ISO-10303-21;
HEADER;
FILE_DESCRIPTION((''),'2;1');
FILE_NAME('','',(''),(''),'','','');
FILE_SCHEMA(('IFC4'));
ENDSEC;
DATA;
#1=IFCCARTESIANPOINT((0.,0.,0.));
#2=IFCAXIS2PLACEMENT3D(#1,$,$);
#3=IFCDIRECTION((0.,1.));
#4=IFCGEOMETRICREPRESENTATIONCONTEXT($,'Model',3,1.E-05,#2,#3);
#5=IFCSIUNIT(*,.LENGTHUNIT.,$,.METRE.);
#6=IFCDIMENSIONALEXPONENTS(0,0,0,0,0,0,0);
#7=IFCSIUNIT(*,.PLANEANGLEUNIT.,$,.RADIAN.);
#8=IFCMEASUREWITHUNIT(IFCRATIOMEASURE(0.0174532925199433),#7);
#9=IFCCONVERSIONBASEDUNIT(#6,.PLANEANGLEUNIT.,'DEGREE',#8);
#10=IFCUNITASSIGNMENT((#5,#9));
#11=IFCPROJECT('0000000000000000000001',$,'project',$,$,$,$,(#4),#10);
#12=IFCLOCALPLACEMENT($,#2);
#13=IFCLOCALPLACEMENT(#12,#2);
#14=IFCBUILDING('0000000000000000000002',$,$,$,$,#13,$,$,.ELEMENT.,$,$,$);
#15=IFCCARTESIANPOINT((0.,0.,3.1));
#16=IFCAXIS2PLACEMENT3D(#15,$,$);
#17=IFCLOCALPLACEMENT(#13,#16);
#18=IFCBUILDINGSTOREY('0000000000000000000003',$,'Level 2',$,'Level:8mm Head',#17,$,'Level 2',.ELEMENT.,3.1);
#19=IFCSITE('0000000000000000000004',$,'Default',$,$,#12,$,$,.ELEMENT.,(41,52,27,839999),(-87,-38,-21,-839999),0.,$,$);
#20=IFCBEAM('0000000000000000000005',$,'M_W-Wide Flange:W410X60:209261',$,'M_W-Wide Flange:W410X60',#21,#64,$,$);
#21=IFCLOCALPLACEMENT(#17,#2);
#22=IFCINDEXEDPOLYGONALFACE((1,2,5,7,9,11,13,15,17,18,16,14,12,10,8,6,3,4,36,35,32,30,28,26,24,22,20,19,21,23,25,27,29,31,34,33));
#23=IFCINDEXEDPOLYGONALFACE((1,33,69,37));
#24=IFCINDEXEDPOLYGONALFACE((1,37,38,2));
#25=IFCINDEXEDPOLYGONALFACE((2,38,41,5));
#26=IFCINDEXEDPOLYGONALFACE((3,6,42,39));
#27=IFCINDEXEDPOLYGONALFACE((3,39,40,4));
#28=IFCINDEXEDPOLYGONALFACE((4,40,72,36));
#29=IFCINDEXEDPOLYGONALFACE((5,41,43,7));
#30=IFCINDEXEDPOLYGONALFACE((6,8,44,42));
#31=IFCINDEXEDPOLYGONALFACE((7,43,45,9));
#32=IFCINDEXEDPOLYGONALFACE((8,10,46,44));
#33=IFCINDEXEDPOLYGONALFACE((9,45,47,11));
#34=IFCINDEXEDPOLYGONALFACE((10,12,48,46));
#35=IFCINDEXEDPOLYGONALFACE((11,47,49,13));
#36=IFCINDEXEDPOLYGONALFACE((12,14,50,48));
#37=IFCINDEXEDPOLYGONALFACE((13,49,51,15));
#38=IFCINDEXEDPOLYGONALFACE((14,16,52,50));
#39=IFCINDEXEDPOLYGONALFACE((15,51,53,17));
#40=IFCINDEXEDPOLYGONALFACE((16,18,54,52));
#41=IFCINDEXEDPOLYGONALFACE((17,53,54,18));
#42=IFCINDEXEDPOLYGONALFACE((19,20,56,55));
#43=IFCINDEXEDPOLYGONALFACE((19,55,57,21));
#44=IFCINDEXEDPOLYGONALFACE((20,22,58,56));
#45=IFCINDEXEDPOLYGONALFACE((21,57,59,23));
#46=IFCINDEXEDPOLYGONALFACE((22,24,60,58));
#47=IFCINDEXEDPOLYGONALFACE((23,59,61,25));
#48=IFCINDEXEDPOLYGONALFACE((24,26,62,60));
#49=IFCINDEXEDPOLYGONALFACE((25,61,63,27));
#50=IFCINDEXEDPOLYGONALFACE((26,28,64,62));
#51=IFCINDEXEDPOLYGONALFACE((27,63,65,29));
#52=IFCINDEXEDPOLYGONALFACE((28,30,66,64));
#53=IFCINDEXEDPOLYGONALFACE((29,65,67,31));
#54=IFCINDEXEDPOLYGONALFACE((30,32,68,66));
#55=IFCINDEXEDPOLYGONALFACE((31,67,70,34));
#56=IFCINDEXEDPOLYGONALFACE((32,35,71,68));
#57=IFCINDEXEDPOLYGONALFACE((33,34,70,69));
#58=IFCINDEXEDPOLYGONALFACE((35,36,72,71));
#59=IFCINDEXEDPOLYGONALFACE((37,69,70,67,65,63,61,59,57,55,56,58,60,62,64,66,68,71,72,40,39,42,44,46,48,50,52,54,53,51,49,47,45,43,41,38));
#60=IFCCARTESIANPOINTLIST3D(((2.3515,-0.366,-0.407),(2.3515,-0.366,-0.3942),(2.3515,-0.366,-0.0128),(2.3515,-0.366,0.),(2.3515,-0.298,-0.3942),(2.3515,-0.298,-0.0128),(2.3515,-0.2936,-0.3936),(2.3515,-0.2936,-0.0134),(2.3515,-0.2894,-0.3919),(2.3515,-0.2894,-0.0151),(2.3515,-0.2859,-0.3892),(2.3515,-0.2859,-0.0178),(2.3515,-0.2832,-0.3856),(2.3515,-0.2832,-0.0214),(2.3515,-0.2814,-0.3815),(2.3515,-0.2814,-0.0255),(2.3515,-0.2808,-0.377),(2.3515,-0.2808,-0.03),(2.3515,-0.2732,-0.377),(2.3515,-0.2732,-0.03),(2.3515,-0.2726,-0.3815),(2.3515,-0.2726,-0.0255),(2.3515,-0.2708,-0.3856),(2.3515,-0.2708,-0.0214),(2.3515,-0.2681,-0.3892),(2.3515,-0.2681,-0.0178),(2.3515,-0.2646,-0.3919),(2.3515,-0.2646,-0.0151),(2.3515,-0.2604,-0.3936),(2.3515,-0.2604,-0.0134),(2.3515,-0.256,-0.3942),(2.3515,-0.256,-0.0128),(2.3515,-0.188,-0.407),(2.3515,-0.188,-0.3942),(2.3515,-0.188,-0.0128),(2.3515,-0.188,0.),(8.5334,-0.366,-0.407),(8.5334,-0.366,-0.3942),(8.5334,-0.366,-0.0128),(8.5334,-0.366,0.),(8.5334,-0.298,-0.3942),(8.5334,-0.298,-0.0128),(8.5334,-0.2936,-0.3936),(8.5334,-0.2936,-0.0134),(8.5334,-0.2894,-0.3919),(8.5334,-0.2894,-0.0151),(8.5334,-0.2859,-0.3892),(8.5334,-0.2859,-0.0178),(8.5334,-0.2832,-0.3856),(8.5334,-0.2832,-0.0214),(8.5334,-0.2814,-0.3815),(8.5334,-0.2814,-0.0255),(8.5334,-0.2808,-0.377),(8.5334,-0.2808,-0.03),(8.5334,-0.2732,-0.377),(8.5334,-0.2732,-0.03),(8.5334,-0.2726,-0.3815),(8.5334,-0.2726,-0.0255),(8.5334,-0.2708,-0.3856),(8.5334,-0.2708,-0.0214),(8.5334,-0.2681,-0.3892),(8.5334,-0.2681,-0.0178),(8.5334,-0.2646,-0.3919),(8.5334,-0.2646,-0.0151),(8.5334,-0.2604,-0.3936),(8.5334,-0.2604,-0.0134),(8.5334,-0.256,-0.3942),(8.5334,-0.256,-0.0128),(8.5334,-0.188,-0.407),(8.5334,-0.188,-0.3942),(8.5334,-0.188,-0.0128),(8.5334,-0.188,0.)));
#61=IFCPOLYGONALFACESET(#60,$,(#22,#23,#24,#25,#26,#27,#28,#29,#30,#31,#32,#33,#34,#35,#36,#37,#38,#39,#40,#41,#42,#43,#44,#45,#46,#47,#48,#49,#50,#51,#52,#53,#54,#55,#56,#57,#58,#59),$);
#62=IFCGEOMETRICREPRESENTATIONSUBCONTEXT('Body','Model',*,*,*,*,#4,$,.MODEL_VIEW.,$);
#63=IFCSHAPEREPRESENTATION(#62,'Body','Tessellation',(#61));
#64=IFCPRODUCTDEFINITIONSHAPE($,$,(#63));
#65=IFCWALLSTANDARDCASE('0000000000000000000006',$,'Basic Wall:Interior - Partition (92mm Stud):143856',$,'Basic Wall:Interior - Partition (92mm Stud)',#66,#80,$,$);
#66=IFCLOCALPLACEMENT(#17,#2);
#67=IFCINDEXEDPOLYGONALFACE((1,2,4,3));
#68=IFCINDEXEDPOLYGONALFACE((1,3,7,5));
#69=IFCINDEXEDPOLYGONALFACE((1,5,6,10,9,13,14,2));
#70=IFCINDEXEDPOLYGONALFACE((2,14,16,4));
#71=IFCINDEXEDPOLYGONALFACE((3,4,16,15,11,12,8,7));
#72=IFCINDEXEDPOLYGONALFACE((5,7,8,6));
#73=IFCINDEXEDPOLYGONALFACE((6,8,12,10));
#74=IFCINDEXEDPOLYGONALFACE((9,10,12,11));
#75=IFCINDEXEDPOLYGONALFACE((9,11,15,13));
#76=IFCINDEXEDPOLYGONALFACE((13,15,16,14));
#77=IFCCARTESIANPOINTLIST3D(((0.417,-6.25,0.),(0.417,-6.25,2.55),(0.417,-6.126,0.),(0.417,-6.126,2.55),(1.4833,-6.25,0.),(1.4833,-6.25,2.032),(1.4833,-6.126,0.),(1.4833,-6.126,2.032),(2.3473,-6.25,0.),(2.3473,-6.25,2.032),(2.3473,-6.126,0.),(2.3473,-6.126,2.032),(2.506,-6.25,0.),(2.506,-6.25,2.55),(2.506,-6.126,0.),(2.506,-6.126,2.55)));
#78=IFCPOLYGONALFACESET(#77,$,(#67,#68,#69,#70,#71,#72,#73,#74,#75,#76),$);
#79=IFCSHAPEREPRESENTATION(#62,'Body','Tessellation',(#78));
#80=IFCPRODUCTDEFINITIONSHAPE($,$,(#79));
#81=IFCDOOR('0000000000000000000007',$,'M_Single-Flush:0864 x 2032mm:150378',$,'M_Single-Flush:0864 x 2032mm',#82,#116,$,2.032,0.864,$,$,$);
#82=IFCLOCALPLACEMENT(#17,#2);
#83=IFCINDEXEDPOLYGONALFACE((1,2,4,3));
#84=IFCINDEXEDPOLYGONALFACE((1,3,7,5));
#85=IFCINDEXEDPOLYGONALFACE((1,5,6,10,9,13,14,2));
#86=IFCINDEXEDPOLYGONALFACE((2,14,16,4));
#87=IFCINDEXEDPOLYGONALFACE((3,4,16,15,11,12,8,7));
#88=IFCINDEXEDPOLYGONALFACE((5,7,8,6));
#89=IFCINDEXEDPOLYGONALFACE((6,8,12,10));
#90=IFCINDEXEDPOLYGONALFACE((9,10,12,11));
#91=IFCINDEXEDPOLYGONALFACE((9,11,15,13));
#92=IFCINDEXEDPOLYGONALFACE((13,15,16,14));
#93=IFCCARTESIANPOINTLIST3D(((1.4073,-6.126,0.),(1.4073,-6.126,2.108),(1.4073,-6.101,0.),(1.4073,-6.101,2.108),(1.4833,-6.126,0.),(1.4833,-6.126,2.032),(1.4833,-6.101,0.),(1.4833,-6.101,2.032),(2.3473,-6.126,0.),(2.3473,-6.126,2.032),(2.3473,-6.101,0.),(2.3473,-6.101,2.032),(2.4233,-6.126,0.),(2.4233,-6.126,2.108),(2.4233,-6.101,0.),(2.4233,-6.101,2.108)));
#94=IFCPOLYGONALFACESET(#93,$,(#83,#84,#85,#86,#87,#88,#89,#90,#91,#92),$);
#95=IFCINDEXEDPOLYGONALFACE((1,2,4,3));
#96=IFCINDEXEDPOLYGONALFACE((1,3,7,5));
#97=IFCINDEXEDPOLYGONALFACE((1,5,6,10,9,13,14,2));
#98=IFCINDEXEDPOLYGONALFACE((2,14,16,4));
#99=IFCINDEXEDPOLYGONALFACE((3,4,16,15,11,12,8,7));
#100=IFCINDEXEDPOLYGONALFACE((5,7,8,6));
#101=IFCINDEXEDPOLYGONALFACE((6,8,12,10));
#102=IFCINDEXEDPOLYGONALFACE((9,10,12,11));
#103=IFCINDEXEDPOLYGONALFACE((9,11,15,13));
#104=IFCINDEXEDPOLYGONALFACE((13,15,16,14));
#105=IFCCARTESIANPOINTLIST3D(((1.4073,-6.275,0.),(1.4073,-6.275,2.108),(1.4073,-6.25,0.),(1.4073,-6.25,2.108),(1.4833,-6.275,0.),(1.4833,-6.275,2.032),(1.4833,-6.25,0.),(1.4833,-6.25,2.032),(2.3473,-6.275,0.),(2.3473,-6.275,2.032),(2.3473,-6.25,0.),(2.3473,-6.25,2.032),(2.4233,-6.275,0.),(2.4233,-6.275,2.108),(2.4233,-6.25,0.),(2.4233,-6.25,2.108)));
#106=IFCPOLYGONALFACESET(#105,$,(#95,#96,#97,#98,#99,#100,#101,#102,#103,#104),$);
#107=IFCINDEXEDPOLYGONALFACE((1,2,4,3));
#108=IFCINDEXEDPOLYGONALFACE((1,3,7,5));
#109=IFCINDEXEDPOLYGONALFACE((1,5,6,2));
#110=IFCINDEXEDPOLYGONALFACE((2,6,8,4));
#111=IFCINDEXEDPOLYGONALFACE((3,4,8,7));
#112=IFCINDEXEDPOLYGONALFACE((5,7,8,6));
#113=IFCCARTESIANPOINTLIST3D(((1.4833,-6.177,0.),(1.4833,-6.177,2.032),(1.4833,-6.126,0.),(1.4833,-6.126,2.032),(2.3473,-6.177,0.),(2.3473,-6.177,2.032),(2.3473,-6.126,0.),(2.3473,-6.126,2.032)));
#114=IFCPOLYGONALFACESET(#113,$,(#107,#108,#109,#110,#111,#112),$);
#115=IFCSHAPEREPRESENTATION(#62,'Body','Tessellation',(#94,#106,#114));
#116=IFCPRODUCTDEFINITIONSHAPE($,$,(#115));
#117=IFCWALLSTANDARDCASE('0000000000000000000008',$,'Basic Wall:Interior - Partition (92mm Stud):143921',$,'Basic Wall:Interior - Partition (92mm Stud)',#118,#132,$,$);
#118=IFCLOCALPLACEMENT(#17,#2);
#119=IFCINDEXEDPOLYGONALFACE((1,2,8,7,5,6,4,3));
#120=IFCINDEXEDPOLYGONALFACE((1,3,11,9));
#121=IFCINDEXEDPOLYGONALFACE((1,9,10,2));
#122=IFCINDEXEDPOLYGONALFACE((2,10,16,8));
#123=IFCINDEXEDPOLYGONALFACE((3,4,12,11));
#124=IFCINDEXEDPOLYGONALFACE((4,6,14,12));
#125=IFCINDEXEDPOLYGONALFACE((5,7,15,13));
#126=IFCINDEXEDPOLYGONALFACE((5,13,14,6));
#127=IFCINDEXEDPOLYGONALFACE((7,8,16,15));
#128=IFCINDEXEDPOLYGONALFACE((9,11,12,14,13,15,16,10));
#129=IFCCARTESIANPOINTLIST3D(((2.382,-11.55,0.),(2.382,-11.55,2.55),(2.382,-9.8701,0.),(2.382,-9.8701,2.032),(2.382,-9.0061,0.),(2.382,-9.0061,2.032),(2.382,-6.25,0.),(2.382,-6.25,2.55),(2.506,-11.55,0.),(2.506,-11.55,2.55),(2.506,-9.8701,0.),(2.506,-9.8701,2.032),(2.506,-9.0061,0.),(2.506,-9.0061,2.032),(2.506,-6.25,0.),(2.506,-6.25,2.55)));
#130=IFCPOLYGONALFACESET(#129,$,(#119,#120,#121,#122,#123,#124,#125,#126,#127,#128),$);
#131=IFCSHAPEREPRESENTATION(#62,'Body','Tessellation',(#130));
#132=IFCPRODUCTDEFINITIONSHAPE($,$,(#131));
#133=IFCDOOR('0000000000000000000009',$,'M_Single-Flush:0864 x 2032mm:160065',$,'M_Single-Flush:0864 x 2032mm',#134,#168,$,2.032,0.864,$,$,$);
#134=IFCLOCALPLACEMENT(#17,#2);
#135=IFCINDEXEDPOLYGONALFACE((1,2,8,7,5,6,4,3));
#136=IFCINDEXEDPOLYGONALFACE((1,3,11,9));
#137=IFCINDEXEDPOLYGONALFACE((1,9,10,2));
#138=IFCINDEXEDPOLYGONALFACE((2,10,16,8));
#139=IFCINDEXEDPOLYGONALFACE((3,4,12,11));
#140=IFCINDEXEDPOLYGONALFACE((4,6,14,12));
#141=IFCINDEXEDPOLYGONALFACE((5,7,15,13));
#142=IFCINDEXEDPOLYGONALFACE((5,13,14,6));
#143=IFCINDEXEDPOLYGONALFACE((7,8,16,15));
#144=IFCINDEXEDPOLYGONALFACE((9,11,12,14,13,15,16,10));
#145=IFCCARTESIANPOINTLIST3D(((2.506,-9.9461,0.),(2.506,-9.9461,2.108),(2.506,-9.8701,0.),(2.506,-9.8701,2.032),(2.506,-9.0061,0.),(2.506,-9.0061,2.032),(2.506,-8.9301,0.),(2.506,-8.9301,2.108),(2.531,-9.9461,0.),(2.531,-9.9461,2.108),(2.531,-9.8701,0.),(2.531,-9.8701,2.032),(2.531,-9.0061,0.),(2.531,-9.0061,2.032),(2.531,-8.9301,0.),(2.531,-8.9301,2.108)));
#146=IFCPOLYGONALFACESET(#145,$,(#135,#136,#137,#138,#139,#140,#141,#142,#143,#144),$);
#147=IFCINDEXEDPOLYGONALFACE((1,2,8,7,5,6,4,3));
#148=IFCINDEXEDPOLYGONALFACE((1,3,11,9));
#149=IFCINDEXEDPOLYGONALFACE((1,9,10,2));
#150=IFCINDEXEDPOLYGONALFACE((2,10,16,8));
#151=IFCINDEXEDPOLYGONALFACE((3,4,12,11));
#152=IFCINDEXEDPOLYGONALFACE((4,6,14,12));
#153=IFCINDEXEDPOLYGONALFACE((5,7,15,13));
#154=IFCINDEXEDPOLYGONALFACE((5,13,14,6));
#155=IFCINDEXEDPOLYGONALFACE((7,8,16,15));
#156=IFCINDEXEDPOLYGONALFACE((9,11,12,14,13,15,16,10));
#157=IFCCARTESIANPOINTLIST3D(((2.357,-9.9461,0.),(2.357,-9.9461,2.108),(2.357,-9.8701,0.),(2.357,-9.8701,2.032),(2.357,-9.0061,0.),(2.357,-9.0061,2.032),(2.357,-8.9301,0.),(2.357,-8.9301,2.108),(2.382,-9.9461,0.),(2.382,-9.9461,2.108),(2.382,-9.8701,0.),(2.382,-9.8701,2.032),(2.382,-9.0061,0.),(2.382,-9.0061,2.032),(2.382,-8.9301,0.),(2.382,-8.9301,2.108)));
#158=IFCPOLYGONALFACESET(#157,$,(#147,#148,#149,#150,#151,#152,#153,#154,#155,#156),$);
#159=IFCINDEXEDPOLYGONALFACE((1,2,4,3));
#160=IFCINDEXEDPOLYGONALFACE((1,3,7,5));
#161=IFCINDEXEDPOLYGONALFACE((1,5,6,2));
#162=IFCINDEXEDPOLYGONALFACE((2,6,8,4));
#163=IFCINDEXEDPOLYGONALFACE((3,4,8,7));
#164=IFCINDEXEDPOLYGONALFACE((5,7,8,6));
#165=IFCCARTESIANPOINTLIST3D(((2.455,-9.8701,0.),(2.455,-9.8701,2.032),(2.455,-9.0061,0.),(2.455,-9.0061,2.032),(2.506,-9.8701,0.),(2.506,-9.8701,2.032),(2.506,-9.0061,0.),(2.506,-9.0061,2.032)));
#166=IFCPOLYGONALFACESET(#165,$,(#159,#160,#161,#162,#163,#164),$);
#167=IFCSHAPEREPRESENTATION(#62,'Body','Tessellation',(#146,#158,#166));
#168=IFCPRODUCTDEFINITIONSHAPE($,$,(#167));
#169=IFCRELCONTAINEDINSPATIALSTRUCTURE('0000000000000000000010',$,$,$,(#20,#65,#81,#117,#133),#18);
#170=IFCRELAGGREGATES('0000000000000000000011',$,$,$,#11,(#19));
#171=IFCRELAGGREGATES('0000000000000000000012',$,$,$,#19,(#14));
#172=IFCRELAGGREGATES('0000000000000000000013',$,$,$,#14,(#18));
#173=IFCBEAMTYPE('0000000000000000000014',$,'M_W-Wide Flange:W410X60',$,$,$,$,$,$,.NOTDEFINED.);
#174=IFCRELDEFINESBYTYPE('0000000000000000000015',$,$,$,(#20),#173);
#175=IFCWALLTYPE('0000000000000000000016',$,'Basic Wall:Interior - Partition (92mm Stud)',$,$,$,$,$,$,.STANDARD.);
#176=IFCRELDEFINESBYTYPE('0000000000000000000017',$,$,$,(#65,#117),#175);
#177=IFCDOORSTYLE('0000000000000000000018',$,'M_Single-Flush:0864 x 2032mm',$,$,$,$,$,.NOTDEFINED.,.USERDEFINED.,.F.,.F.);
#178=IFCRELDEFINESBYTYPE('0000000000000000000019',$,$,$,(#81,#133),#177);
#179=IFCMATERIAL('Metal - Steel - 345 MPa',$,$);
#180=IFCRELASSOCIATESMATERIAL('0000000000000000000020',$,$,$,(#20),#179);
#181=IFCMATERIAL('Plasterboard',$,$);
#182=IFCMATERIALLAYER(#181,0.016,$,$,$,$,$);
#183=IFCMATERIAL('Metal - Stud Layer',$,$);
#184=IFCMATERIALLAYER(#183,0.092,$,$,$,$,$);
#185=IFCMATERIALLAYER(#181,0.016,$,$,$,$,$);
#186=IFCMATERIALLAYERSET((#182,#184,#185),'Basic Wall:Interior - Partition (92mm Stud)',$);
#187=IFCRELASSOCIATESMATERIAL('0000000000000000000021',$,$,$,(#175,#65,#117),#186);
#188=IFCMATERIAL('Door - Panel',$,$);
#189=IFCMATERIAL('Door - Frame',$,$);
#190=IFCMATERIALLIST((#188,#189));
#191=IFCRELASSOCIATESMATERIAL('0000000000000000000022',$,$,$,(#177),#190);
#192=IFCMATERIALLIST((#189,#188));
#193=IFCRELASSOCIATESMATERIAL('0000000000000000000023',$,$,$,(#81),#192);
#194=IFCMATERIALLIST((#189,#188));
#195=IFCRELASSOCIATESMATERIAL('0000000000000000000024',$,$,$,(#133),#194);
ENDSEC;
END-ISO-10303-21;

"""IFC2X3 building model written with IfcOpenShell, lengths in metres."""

from ifc_helpers import new_model, entity, si_unit, converted_unit, direction, frame, frame_2d, origin, origin_2d_with_axis, place, context, subcontext, project, spatial, polyline, rectangle, i_section, outline, extrude, source, transform, mapped, material, material_list, layer, layer_set, layer_usage, type_object, type_shapes, element, fill, save


model = new_model("IFC2X3")

# Units and contexts
model_context = context("Model", 3, precision=1e-05, world=origin(), true_north=direction((0.0, 1.0)))
body_context = subcontext(model_context, "Body", "Model", "MODEL_VIEW")
ifc_project = project(units=[si_unit("LENGTHUNIT", "METRE"), converted_unit("PLANEANGLEUNIT", "DEGREE", entity("IfcRatioMeasure", 0.0174532925199433), si_unit("PLANEANGLEUNIT", "RADIAN"), dimensions=[0, 0, 0, 0, 0, 0, 0])], contexts=[model_context])

# Site, building, storey
site_placement = place(None, origin())
site = spatial("IfcSite", under=ifc_project, at=site_placement, Name="Default", CompositionType="ELEMENT", RefLatitude=(41, 52, 27, 839999), RefLongitude=(-87, -38, -21, -839999), RefElevation=0.0)
building_placement = place(site_placement, origin())
building = spatial("IfcBuilding", under=site, at=building_placement, CompositionType="ELEMENT")
storey_placement = place(building_placement, frame((0.0, 0.0, 3.1)))
storey = spatial("IfcBuildingStorey", under=building, at=storey_placement, Name="Level 2", ObjectType="Level:8mm Head", LongName="Level 2", CompositionType="ELEMENT", Elevation=3.1)

# Beam
ifc_material_1 = material(Name="Metal - Steel - 345 MPa")
beam_type = type_object("IfcBeamType", Name="M_W-Wide Flange:W410X60", PredefinedType="NOTDEFINED")
beam_placement = place(storey_placement, frame((8.5334, -0.277, 0.0), z_axis=(0.0, 0.0, 1.0), x_axis=(-1.0, 0.0, 0.0)))
element("IfcBeam", 1, at=beam_placement, inside=storey, type_object=beam_type, material=ifc_material_1, Name="M_W-Wide Flange:W410X60:209261", ObjectType="M_W-Wide Flange:W410X60", context=body_context, shape_type="SweptSolid", body=[
    extrude(i_section(OverallWidth=0.178, OverallDepth=0.407, WebThickness=0.0077, FlangeThickness=0.0128, FilletRadius=0.0172, at=frame_2d((0.0, 0.0), x_axis=(0.0, 1.0))), frame((0.0, 0.0, -0.2035), z_axis=(1.0, 0.0, 0.0), x_axis=(0.0, 0.0, -1.0)), (0.0, 0.0, 1.0), 6.1819),
])

# Shared definitions
ifc_material_2 = material(Name="Metal - Stud Layer")
ifc_material_3 = material(Name="Plasterboard")

# Walls, openings, doors
ifc_layer_1 = layer(ifc_material_3, 0.016)
ifc_layer_2 = layer(ifc_material_2, 0.092)
ifc_layer_3 = layer(ifc_material_3, 0.016)
ifc_layer_set_1 = layer_set([ifc_layer_1, ifc_layer_2, ifc_layer_3], Name="Basic Wall:Interior - Partition (92mm Stud)")
ifc_layer_usage_1 = layer_usage(ifc_layer_set_1, "AXIS2", "NEGATIVE", 0.062)
wall_type_1 = type_object("IfcWallType", Name="Basic Wall:Interior - Partition (92mm Stud)", PredefinedType="STANDARD", material=ifc_layer_set_1)
wall_1_placement = place(storey_placement, frame((0.417, -6.188, 0.0)))
wall_1 = element("IfcWallStandardCase", 2, at=wall_1_placement, inside=storey, type_object=wall_type_1, material=ifc_layer_usage_1, Name="Basic Wall:Interior - Partition (92mm Stud):143856", ObjectType="Basic Wall:Interior - Partition (92mm Stud)", context=body_context, shape_type="SweptSolid", body=[
    extrude(rectangle(XDim=2.089, YDim=0.124, at=frame_2d((1.0445, 0.0), x_axis=(-1.0, 0.0))), origin(), (0.0, 0.0, 1.0), 2.55),
])
opening_1_placement = place(wall_1_placement, frame((1.0663, -0.062, 0.0)))
opening_1 = element("IfcOpeningElement", 3, at=opening_1_placement, cuts=wall_1, ObjectType="Opening", context=body_context, shape_type="SweptSolid", body=[
    extrude(rectangle(XDim=0.864, YDim=2.032, at=frame_2d((1.016, 0.432), x_axis=(0.0, 1.0))), frame((0.0, 0.0, 0.0), z_axis=(0.0, 1.0, 0.0), x_axis=(0.0, 0.0, 1.0)), (0.0, 0.0, 1.0), 0.124),
])
ifc_material_4 = material(Name="Door - Frame")
ifc_material_5 = material(Name="Door - Panel")
ifc_material_list_1 = material_list([ifc_material_4, ifc_material_5])
ifc_material_list_2 = material_list([ifc_material_5, ifc_material_4])
door_style_1 = type_object("IfcDoorStyle", Name="M_Single-Flush:0864 x 2032mm", ConstructionType="USERDEFINED", OperationType="NOTDEFINED", ParameterTakesPrecedence=False, Sizeable=False, material=ifc_material_list_2)
shared_shape_1 = source(origin(), body_context, "Body", "SweptSolid", [
    extrude(outline(polyline([(-0.508, -1.073), (0.508, -1.073), (0.508, 1.035), (0.432, 1.035), (0.432, -0.997), (-0.432, -0.997), (-0.432, 1.035), (-0.508, 1.035), (-0.508, -1.073)])), frame((0.432, 0.124, 1.035), z_axis=(0.0, 1.0, 0.0), x_axis=(1.0, 0.0, 0.0)), (0.0, 0.0, 1.0), 0.025),
    extrude(outline(polyline([(-1.073, -0.508), (1.035, -0.508), (1.035, -0.432), (-0.997, -0.432), (-0.997, 0.432), (1.035, 0.432), (1.035, 0.508), (-1.073, 0.508), (-1.073, -0.508)])), frame((0.432, -0.025, 1.035), z_axis=(0.0, 1.0, 0.0), x_axis=(0.0, 0.0, -1.0)), (0.0, 0.0, 1.0), 0.025),
    extrude(rectangle(XDim=0.051, YDim=0.864, at=origin_2d_with_axis()), frame((0.432, 0.0985, 0.0), z_axis=(0.0, 0.0, 1.0), x_axis=(0.0, 1.0, 0.0)), (0.0, 0.0, 1.0), 2.032),
])
type_shapes(door_style_1, [shared_shape_1])
door_1_placement = place(opening_1_placement, origin())
door_1 = element("IfcDoor", 4, at=door_1_placement, inside=storey, type_object=door_style_1, material=ifc_material_list_1, Name="M_Single-Flush:0864 x 2032mm:150378", ObjectType="M_Single-Flush:0864 x 2032mm", OverallHeight=2.032, OverallWidth=0.864, context=body_context, shape_type="MappedRepresentation", body=[
    mapped(shared_shape_1, transform((0.0, 0.0, 0.0), scale=1.0)),
])
fill(opening_1, door_1)
ifc_layer_usage_2 = layer_usage(ifc_layer_set_1, "AXIS2", "NEGATIVE", 0.062)
wall_2_placement = place(storey_placement, frame((2.444, -6.25, 0.0), z_axis=(0.0, 0.0, 1.0), x_axis=(0.0, -1.0, 0.0)))
wall_2 = element("IfcWallStandardCase", 5, at=wall_2_placement, inside=storey, type_object=wall_type_1, material=ifc_layer_usage_2, Name="Basic Wall:Interior - Partition (92mm Stud):143921", ObjectType="Basic Wall:Interior - Partition (92mm Stud)", context=body_context, shape_type="SweptSolid", body=[
    extrude(rectangle(XDim=5.3, YDim=0.124, at=frame_2d((2.65, 0.0), x_axis=(-1.0, 0.0))), origin(), (0.0, 0.0, 1.0), 2.55),
])
opening_2_placement = place(wall_2_placement, frame((2.7561, -0.062, 0.0)))
opening_2 = element("IfcOpeningElement", 6, at=opening_2_placement, cuts=wall_2, ObjectType="Opening", context=body_context, shape_type="SweptSolid", body=[
    extrude(rectangle(XDim=0.864, YDim=2.032, at=frame_2d((1.016, 0.432), x_axis=(0.0, 1.0))), frame((0.0, 0.0, 0.0), z_axis=(0.0, 1.0, 0.0), x_axis=(0.0, 0.0, 1.0)), (0.0, 0.0, 1.0), 0.124),
])
ifc_material_list_3 = material_list([ifc_material_4, ifc_material_5])
door_2_placement = place(opening_2_placement, origin())
door_2 = element("IfcDoor", 7, at=door_2_placement, inside=storey, type_object=door_style_1, material=ifc_material_list_3, Name="M_Single-Flush:0864 x 2032mm:160065", ObjectType="M_Single-Flush:0864 x 2032mm", OverallHeight=2.032, OverallWidth=0.864, context=body_context, shape_type="MappedRepresentation", body=[
    mapped(shared_shape_1, transform((0.0, 0.0, 0.0), scale=1.0)),
])
fill(opening_2, door_2)

save(model, "model.ifc")
